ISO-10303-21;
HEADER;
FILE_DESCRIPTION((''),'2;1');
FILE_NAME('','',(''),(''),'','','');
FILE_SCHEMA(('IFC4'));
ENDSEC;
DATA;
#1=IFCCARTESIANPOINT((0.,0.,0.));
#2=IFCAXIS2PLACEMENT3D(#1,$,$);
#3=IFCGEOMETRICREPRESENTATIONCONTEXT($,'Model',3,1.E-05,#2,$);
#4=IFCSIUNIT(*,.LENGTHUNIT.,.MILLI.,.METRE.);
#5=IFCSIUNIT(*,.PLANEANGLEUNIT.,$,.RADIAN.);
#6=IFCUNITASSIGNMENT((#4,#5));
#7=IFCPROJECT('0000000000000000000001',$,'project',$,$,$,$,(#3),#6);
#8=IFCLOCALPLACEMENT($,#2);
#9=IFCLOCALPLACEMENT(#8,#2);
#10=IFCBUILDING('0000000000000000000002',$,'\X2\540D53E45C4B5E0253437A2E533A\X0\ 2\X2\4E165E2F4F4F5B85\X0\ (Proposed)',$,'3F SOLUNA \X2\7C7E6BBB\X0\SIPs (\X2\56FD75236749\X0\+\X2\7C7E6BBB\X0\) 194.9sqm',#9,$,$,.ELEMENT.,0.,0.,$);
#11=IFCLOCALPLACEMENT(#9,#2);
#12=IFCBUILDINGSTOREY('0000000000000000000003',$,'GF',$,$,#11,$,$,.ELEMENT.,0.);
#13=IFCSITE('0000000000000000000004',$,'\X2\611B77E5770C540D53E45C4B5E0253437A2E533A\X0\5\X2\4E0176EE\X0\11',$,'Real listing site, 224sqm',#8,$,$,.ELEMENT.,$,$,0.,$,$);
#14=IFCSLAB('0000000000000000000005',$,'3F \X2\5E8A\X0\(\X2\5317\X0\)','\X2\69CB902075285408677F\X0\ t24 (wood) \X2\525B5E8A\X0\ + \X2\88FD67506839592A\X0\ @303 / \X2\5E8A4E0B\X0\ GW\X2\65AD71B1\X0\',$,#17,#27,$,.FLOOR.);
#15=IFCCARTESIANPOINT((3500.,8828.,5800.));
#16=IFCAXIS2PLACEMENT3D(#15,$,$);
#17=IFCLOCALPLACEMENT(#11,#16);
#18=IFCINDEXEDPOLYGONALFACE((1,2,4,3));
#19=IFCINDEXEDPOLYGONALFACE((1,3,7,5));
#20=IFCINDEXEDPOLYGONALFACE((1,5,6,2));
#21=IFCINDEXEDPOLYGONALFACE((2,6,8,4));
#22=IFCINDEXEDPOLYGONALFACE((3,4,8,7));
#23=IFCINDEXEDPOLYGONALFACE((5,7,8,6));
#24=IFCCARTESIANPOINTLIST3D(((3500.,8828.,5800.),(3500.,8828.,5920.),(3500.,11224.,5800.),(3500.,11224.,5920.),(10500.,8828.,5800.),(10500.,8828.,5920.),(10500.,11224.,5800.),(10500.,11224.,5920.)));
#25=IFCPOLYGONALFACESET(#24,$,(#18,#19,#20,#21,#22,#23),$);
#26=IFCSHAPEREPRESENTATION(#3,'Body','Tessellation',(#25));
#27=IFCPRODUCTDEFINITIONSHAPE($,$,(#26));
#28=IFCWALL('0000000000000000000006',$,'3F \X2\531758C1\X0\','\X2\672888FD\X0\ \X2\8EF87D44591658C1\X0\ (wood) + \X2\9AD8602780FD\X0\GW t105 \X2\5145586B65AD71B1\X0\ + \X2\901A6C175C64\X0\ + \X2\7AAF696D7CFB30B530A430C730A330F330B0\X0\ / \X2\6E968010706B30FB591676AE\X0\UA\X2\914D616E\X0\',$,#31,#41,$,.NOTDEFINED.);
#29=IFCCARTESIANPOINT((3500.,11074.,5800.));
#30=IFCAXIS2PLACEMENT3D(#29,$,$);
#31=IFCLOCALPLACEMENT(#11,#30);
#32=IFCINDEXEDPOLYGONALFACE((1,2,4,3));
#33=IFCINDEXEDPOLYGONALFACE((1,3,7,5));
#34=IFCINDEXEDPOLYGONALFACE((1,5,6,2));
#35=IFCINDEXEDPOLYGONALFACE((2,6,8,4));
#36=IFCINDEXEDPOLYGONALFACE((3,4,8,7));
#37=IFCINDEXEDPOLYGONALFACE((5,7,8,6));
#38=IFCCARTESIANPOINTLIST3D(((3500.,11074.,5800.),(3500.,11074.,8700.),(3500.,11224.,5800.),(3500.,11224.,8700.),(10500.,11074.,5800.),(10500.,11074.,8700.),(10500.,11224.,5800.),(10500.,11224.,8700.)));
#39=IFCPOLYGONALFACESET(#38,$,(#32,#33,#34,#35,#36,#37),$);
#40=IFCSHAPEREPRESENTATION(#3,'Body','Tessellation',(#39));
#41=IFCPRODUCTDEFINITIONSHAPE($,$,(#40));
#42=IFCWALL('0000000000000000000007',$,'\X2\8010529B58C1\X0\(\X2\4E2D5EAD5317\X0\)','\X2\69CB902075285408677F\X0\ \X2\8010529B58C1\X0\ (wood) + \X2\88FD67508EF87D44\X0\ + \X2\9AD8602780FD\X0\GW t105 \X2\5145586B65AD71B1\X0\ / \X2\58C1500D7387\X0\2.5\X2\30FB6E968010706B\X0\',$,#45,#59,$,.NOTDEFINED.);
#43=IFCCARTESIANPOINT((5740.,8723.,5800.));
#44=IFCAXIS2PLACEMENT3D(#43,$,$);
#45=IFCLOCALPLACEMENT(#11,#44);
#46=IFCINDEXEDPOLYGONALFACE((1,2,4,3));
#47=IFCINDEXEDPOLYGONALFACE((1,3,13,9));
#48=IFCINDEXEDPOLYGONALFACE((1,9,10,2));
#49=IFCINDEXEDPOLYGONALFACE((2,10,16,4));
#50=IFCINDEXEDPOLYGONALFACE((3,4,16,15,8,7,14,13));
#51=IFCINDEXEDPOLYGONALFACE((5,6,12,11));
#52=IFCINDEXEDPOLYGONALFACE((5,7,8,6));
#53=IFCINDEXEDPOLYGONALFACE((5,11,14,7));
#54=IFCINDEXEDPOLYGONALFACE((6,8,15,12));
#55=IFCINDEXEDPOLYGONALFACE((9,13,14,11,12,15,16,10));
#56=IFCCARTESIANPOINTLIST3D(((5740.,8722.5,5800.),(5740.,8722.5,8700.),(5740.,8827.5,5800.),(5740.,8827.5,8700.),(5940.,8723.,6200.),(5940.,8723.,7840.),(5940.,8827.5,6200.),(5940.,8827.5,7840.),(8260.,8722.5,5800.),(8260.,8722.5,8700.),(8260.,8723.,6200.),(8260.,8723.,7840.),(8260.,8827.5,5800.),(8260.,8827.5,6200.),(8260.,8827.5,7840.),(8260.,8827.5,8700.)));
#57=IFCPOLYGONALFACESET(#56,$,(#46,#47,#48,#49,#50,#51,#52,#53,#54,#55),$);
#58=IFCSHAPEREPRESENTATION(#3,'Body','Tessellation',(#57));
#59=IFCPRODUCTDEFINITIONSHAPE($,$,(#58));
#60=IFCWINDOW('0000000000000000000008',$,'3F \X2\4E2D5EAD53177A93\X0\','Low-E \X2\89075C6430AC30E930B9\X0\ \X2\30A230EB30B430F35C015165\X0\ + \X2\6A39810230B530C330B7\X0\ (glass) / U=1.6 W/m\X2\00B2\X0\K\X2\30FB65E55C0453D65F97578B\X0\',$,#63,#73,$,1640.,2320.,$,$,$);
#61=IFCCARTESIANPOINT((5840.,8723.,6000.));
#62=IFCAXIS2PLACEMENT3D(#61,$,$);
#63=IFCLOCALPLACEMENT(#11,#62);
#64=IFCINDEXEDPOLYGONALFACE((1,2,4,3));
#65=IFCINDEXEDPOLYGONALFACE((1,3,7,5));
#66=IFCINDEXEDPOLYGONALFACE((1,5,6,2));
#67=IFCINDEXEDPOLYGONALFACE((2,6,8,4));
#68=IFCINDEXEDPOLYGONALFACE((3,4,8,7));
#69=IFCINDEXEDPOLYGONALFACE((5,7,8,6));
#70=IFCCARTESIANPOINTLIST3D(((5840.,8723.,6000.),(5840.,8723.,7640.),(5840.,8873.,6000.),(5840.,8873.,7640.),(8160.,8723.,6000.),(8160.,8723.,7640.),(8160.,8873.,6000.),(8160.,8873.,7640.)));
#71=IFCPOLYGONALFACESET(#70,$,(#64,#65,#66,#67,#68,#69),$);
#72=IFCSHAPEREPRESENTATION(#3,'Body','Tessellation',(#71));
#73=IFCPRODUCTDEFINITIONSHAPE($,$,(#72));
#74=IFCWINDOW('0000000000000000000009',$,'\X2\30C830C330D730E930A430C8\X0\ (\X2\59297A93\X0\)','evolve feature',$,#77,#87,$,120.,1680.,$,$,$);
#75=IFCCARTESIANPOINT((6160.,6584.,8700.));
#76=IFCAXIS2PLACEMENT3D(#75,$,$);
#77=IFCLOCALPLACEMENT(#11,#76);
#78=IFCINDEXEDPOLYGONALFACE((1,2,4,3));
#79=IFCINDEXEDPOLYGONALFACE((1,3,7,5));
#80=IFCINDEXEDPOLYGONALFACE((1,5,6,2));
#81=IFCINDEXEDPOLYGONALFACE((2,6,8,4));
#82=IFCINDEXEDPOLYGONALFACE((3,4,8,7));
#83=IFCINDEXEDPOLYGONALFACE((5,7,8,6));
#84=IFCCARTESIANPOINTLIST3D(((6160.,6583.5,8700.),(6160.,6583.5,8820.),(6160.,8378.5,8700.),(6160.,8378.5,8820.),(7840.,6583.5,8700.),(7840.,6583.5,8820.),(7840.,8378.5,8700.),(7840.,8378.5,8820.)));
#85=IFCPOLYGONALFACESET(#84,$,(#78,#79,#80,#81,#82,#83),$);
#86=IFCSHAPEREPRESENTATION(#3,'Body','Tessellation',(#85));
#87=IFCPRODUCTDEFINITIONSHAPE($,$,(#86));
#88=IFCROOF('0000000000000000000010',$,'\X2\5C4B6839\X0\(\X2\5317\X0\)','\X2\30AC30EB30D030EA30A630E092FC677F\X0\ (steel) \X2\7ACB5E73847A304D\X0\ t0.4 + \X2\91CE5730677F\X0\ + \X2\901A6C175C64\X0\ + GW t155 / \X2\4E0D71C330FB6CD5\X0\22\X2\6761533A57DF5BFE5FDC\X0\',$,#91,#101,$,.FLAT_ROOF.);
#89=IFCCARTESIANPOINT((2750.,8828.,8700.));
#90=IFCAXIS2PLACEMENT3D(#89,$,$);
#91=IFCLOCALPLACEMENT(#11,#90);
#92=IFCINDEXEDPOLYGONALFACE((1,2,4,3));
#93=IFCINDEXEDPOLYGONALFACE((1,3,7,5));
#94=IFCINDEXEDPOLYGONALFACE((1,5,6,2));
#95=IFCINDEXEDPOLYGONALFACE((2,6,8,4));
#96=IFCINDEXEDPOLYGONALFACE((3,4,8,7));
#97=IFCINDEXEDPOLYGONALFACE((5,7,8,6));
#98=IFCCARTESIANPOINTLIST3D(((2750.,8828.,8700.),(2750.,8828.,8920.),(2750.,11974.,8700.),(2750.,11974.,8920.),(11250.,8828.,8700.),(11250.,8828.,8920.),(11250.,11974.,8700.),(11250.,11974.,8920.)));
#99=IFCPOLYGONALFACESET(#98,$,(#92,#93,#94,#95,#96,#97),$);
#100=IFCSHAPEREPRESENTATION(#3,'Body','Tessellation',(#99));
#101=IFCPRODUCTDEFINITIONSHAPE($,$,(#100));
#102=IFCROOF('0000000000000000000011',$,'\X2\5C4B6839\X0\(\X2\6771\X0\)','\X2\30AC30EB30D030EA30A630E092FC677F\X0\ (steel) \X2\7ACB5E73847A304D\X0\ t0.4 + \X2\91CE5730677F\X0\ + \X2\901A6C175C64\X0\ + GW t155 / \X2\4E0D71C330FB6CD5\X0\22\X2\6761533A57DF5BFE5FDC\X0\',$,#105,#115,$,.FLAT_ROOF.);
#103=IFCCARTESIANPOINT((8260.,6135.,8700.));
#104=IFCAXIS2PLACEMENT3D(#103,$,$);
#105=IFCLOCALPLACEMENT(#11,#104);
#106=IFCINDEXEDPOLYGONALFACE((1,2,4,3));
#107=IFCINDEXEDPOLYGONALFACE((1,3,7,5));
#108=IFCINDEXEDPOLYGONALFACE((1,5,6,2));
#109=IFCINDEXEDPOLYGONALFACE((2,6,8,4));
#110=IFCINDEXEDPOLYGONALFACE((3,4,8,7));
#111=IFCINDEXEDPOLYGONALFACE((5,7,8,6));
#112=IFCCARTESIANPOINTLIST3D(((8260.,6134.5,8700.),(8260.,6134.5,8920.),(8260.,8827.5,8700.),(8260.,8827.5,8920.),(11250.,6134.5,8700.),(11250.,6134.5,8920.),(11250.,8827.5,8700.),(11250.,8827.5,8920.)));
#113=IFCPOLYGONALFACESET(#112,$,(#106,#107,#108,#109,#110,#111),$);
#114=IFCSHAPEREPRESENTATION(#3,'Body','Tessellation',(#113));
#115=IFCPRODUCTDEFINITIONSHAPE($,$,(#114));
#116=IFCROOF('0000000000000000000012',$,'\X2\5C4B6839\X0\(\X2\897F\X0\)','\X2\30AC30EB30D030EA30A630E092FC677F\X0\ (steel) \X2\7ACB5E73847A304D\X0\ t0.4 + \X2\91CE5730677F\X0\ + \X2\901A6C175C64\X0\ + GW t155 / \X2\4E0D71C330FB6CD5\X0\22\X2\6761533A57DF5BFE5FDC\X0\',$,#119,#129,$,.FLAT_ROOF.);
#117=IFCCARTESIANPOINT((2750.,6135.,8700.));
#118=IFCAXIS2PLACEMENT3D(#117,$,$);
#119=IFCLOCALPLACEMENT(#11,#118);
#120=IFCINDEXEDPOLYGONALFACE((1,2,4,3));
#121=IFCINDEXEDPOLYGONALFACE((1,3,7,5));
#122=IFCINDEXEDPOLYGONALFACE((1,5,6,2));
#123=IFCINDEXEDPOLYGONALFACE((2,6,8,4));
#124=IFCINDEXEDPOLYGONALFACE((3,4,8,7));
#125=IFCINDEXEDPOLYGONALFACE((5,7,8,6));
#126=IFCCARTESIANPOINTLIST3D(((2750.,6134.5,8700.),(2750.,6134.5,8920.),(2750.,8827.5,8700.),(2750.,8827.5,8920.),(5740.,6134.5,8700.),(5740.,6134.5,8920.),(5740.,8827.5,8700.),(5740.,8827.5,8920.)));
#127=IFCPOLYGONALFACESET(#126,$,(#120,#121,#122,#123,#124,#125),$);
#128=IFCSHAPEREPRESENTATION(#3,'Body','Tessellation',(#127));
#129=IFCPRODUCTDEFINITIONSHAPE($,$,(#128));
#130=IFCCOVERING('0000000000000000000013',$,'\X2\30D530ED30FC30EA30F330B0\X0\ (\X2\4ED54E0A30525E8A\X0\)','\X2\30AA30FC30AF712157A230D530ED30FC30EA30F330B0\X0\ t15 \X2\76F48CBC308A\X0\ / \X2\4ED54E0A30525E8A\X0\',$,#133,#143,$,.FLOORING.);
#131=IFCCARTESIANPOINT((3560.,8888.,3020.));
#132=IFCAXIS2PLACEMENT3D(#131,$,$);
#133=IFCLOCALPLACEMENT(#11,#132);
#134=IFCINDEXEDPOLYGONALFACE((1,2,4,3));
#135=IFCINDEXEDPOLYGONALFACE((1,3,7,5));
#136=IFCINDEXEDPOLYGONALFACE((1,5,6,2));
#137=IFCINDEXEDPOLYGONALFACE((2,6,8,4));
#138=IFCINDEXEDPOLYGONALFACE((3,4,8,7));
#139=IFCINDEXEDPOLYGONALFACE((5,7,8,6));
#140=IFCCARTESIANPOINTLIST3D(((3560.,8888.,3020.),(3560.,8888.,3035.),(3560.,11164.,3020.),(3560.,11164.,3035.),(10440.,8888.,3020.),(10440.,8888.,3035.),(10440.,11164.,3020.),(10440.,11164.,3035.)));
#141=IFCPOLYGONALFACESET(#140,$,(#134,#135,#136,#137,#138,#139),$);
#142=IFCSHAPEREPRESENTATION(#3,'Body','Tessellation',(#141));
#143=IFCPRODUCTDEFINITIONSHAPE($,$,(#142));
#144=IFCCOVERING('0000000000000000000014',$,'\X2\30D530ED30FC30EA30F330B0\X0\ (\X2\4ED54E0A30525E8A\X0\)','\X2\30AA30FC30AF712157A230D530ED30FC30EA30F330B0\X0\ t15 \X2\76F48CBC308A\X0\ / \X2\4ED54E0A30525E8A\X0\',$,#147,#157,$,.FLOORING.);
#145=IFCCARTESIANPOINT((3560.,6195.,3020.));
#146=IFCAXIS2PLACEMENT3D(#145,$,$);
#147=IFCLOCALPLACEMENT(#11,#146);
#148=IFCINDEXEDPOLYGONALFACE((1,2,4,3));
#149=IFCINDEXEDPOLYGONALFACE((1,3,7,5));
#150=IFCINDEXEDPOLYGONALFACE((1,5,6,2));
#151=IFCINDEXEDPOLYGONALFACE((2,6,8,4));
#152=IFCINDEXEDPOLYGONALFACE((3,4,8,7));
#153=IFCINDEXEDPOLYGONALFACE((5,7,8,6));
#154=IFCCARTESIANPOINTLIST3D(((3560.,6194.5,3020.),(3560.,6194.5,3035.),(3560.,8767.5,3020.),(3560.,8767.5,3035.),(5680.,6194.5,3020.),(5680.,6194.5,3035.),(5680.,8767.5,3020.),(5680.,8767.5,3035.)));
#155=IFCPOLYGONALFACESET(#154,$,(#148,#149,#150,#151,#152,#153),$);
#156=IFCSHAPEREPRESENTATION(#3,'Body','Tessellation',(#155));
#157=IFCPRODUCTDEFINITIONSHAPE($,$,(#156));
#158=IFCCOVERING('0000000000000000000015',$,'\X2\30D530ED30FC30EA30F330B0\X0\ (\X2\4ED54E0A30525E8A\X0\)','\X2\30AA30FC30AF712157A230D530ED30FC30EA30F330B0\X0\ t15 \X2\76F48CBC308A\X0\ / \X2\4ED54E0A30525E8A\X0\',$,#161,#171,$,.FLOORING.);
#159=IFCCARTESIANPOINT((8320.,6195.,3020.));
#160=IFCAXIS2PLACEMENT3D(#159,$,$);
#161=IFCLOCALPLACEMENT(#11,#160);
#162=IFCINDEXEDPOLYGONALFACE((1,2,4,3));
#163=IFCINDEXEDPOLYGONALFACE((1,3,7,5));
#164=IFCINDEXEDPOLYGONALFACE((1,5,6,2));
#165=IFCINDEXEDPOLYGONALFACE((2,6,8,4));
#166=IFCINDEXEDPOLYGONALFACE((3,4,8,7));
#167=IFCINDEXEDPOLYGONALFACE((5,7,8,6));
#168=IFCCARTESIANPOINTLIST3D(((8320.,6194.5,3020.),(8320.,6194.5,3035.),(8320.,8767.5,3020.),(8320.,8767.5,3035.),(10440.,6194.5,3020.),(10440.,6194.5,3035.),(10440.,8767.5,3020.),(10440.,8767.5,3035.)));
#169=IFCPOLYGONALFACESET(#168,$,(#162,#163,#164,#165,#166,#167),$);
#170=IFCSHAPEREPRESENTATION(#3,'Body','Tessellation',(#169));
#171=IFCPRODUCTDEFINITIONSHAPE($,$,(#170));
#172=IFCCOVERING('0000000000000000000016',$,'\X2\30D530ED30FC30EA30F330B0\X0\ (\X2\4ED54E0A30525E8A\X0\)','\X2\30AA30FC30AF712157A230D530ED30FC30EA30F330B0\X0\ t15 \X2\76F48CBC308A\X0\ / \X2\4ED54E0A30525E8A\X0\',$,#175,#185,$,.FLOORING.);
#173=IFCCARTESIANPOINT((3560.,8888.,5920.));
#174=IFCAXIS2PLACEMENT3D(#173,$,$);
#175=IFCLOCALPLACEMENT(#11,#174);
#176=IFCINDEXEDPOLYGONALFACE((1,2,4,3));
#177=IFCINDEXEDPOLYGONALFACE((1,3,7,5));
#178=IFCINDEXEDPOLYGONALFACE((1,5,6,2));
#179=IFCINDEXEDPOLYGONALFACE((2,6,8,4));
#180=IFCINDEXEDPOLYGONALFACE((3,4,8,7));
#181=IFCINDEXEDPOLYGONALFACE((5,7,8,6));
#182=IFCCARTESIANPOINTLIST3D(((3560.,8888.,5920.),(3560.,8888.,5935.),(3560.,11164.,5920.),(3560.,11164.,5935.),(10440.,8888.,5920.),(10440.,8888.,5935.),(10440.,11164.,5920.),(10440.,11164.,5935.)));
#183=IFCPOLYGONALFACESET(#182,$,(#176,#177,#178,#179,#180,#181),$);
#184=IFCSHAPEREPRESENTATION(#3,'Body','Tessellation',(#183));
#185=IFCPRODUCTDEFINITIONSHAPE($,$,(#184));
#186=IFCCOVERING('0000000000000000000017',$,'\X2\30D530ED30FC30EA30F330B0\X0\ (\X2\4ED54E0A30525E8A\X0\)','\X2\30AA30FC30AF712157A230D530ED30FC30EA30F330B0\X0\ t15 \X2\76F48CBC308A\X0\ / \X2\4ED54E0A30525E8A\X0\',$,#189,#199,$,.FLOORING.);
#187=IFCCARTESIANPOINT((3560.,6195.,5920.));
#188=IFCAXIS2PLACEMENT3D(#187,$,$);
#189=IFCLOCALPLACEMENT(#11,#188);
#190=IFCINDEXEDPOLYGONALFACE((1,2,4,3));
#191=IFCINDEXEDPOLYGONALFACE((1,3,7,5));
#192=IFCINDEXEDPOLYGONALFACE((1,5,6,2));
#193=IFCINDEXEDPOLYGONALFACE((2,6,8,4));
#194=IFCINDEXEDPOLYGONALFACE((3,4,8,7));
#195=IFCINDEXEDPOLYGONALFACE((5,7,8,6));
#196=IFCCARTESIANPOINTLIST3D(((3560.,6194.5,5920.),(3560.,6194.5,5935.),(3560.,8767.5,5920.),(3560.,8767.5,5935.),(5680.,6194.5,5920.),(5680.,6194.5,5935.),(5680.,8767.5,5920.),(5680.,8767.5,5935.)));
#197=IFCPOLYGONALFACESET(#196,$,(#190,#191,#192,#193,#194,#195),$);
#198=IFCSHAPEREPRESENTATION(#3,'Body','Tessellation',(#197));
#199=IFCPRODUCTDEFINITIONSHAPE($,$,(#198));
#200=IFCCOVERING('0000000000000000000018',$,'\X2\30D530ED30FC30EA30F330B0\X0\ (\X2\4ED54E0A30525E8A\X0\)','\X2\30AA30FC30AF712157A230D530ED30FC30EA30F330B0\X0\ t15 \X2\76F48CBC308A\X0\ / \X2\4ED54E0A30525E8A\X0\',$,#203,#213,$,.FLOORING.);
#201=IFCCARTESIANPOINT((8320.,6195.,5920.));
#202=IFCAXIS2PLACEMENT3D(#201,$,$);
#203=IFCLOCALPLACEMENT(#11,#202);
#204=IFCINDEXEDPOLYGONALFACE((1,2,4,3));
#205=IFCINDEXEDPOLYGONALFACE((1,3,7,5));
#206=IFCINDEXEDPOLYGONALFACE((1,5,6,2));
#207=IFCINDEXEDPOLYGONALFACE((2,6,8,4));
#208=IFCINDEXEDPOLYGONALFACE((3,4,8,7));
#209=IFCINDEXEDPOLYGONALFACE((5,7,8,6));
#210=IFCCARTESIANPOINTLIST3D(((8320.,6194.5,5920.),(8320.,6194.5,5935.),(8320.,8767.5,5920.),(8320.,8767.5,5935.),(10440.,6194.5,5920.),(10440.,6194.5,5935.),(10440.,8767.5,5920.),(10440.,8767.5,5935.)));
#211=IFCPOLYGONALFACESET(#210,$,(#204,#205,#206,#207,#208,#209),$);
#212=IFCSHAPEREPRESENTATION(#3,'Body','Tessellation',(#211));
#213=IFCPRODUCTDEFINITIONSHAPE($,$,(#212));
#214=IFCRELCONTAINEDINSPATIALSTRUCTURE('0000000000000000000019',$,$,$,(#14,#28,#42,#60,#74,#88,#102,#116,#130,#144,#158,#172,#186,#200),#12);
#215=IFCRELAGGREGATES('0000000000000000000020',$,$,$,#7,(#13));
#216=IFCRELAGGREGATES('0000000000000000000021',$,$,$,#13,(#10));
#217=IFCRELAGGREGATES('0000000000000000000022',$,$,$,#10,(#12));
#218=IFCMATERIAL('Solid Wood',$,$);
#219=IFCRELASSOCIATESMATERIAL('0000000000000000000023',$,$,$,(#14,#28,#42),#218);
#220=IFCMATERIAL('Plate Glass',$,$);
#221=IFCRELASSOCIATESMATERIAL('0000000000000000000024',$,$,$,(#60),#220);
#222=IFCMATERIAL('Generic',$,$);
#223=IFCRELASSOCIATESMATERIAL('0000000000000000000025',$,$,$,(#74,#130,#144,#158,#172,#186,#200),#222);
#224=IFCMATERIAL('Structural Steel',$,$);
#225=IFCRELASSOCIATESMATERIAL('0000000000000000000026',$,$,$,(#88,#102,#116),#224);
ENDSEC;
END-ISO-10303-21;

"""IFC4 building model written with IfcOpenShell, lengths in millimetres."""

from ifc_helpers import new_model, si_unit, frame, frame_2d, origin, place, context, project, spatial, rectangle, extrude, material, element, fill, save


model = new_model("IFC4")

# Units and contexts
model_context = context("Model", 3, precision=1e-05, world=origin())
ifc_project = project(units=[si_unit("LENGTHUNIT", "METRE", prefix="MILLI"), si_unit("PLANEANGLEUNIT", "RADIAN")], contexts=[model_context])

# Site, building, storey
site_placement = place(None, origin())
site = spatial("IfcSite", under=ifc_project, at=site_placement, Name="愛知県名古屋市千種区5丁目11", ObjectType="Real listing site, 224sqm", CompositionType="ELEMENT", RefElevation=0.0)
building_placement = place(site_placement, origin())
building = spatial("IfcBuilding", under=site, at=building_placement, Name="名古屋市千種区 2世帯住宅 (Proposed)", ObjectType="3F SOLUNA 籾殻SIPs (国産杉+籾殻) 194.9sqm", CompositionType="ELEMENT", ElevationOfRefHeight=0.0, ElevationOfTerrain=0.0)
storey_placement = place(building_placement, origin())
storey = spatial("IfcBuildingStorey", under=building, at=storey_placement, Name="GF", CompositionType="ELEMENT", Elevation=0.0)

# Slab
ifc_material_1 = material(Name="Solid Wood")
slab_placement = place(storey_placement, frame((3500.0, 8828.0, 5800.0)))
element("IfcSlab", 1, at=slab_placement, inside=storey, material=ifc_material_1, Name="3F 床(北)", Description="構造用合板 t24 (wood) 剛床 + 製材根太 @303 / 床下 GW断熱", PredefinedType="FLOOR", context=model_context, shape_type="SweptSolid", body=[
    extrude(rectangle(XDim=7000.0, YDim=2396.0, at=frame_2d((3500.0, 1198.0))), frame((3500.0, 8828.0, 5800.0)), (0.0, 0.0, 1.0), 120.0),
])

# Wall
wall_1_placement = place(storey_placement, frame((3500.0, 11074.0, 5800.0)))
element("IfcWall", 2, at=wall_1_placement, inside=storey, material=ifc_material_1, Name="3F 北壁", Description="木製 軸組外壁 (wood) + 高性能GW t105 充填断熱 + 通気層 + 窯業系サイディング / 準耐火・外皮UA配慮", PredefinedType="NOTDEFINED", context=model_context, shape_type="SweptSolid", body=[
    extrude(rectangle(XDim=7000.0, YDim=150.0, at=frame_2d((3500.0, 75.0))), frame((3500.0, 11074.0, 5800.0)), (0.0, 0.0, 1.0), 2900.0),
])

# Wall, opening, window
wall_2_placement = place(storey_placement, frame((5740.0, 8723.0, 5800.0)))
wall_2 = element("IfcWall", 3, at=wall_2_placement, inside=storey, material=ifc_material_1, Name="耐力壁(中庭北)", Description="構造用合板 耐力壁 (wood) + 製材軸組 + 高性能GW t105 充填断熱 / 壁倍率2.5・準耐火", PredefinedType="NOTDEFINED", context=model_context, shape_type="SweptSolid", body=[
    extrude(rectangle(XDim=2520.0, YDim=105.0, at=frame_2d((1260.0, 52.0))), frame((5740.0, 8723.0, 5800.0)), (0.0, 0.0, 1.0), 2900.0),
])
opening_placement = place(storey_placement, frame((5840.0, 8723.0, 6000.0)))
opening = element("IfcOpeningElement", 4, at=opening_placement, cuts=wall_2, PredefinedType="NOTDEFINED", context=model_context, shape_type="SweptSolid", body=[
    extrude(rectangle(XDim=2320.0, YDim=150.0, at=frame_2d((1160.0, 75.0))), frame((5840.0, 8723.0, 6000.0)), (0.0, 0.0, 1.0), 1640.0),
])
ifc_material_2 = material(Name="Plate Glass")
window_1_placement = place(storey_placement, frame((5840.0, 8723.0, 6000.0)))
window_1 = element("IfcWindow", 5, at=window_1_placement, inside=storey, material=ifc_material_2, Name="3F 中庭北窓", Description="Low-E 複層ガラス アルゴン封入 + 樹脂サッシ (glass) / U=1.6 W/m²K・日射取得型", OverallHeight=1640.0, OverallWidth=2320.0, context=model_context, shape_type="SweptSolid", body=[
    extrude(rectangle(XDim=2320.0, YDim=150.0, at=frame_2d((1160.0, 75.0))), frame((5840.0, 8723.0, 6000.0)), (0.0, 0.0, 1.0), 1640.0),
])
fill(opening, window_1)

# Window
ifc_material_3 = material(Name="Generic")
window_2_placement = place(storey_placement, frame((6160.0, 6584.0, 8700.0)))
element("IfcWindow", 6, at=window_2_placement, inside=storey, material=ifc_material_3, Name="トップライト (天窓)", Description="evolve feature", OverallHeight=120.0, OverallWidth=1680.0, context=model_context, shape_type="SweptSolid", body=[
    extrude(rectangle(XDim=1680.0, YDim=1795.0, at=frame_2d((840.0, 897.0))), frame((6160.0, 6584.0, 8700.0)), (0.0, 0.0, 1.0), 120.0),
])

# Roofs
ifc_material_4 = material(Name="Structural Steel")
roof_1_placement = place(storey_placement, frame((2750.0, 8828.0, 8700.0)))
element("IfcRoof", 7, at=roof_1_placement, inside=storey, material=ifc_material_4, Name="屋根(北)", Description="ガルバリウム鋼板 (steel) 立平葺き t0.4 + 野地板 + 通気層 + GW t155 / 不燃・法22条区域対応", PredefinedType="FLAT_ROOF", context=model_context, shape_type="SweptSolid", body=[
    extrude(rectangle(XDim=8500.0, YDim=3146.0, at=frame_2d((4250.0, 1573.0))), frame((2750.0, 8828.0, 8700.0)), (0.0, 0.0, 1.0), 220.0),
])
roof_2_placement = place(storey_placement, frame((8260.0, 6135.0, 8700.0)))
element("IfcRoof", 8, at=roof_2_placement, inside=storey, material=ifc_material_4, Name="屋根(東)", Description="ガルバリウム鋼板 (steel) 立平葺き t0.4 + 野地板 + 通気層 + GW t155 / 不燃・法22条区域対応", PredefinedType="FLAT_ROOF", context=model_context, shape_type="SweptSolid", body=[
    extrude(rectangle(XDim=2990.0, YDim=2693.0, at=frame_2d((1495.0, 1346.0))), frame((8260.0, 6135.0, 8700.0)), (0.0, 0.0, 1.0), 220.0),
])
roof_3_placement = place(storey_placement, frame((2750.0, 6135.0, 8700.0)))
element("IfcRoof", 9, at=roof_3_placement, inside=storey, material=ifc_material_4, Name="屋根(西)", Description="ガルバリウム鋼板 (steel) 立平葺き t0.4 + 野地板 + 通気層 + GW t155 / 不燃・法22条区域対応", PredefinedType="FLAT_ROOF", context=model_context, shape_type="SweptSolid", body=[
    extrude(rectangle(XDim=2990.0, YDim=2693.0, at=frame_2d((1495.0, 1346.0))), frame((2750.0, 6135.0, 8700.0)), (0.0, 0.0, 1.0), 220.0),
])

# Coverings
covering_1_placement = place(storey_placement, frame((3560.0, 8888.0, 3020.0)))
element("IfcCovering", 10, at=covering_1_placement, inside=storey, material=ifc_material_3, Name="フローリング (仕上げ床)", Description="オーク無垢フローリング t15 直貼り / 仕上げ床", PredefinedType="FLOORING", context=model_context, shape_type="SweptSolid", body=[
    extrude(rectangle(XDim=6880.0, YDim=2276.0, at=frame_2d((3440.0, 1138.0))), frame((3560.0, 8888.0, 3020.0)), (0.0, 0.0, 1.0), 15.0),
])
covering_2_placement = place(storey_placement, frame((3560.0, 6195.0, 3020.0)))
element("IfcCovering", 11, at=covering_2_placement, inside=storey, material=ifc_material_3, Name="フローリング (仕上げ床)", Description="オーク無垢フローリング t15 直貼り / 仕上げ床", PredefinedType="FLOORING", context=model_context, shape_type="SweptSolid", body=[
    extrude(rectangle(XDim=2120.0, YDim=2573.0, at=frame_2d((1060.0, 1286.0))), frame((3560.0, 6195.0, 3020.0)), (0.0, 0.0, 1.0), 15.0),
])
covering_3_placement = place(storey_placement, frame((8320.0, 6195.0, 3020.0)))
element("IfcCovering", 12, at=covering_3_placement, inside=storey, material=ifc_material_3, Name="フローリング (仕上げ床)", Description="オーク無垢フローリング t15 直貼り / 仕上げ床", PredefinedType="FLOORING", context=model_context, shape_type="SweptSolid", body=[
    extrude(rectangle(XDim=2120.0, YDim=2573.0, at=frame_2d((1060.0, 1286.0))), frame((8320.0, 6195.0, 3020.0)), (0.0, 0.0, 1.0), 15.0),
])
covering_4_placement = place(storey_placement, frame((3560.0, 8888.0, 5920.0)))
element("IfcCovering", 13, at=covering_4_placement, inside=storey, material=ifc_material_3, Name="フローリング (仕上げ床)", Description="オーク無垢フローリング t15 直貼り / 仕上げ床", PredefinedType="FLOORING", context=model_context, shape_type="SweptSolid", body=[
    extrude(rectangle(XDim=6880.0, YDim=2276.0, at=frame_2d((3440.0, 1138.0))), frame((3560.0, 8888.0, 5920.0)), (0.0, 0.0, 1.0), 15.0),
])
covering_5_placement = place(storey_placement, frame((3560.0, 6195.0, 5920.0)))
element("IfcCovering", 14, at=covering_5_placement, inside=storey, material=ifc_material_3, Name="フローリング (仕上げ床)", Description="オーク無垢フローリング t15 直貼り / 仕上げ床", PredefinedType="FLOORING", context=model_context, shape_type="SweptSolid", body=[
    extrude(rectangle(XDim=2120.0, YDim=2573.0, at=frame_2d((1060.0, 1286.0))), frame((3560.0, 6195.0, 5920.0)), (0.0, 0.0, 1.0), 15.0),
])
covering_6_placement = place(storey_placement, frame((8320.0, 6195.0, 5920.0)))
element("IfcCovering", 15, at=covering_6_placement, inside=storey, material=ifc_material_3, Name="フローリング (仕上げ床)", Description="オーク無垢フローリング t15 直貼り / 仕上げ床", PredefinedType="FLOORING", context=model_context, shape_type="SweptSolid", body=[
    extrude(rectangle(XDim=2120.0, YDim=2573.0, at=frame_2d((1060.0, 1286.0))), frame((8320.0, 6195.0, 5920.0)), (0.0, 0.0, 1.0), 15.0),
])

save(model, "model.ifc")
